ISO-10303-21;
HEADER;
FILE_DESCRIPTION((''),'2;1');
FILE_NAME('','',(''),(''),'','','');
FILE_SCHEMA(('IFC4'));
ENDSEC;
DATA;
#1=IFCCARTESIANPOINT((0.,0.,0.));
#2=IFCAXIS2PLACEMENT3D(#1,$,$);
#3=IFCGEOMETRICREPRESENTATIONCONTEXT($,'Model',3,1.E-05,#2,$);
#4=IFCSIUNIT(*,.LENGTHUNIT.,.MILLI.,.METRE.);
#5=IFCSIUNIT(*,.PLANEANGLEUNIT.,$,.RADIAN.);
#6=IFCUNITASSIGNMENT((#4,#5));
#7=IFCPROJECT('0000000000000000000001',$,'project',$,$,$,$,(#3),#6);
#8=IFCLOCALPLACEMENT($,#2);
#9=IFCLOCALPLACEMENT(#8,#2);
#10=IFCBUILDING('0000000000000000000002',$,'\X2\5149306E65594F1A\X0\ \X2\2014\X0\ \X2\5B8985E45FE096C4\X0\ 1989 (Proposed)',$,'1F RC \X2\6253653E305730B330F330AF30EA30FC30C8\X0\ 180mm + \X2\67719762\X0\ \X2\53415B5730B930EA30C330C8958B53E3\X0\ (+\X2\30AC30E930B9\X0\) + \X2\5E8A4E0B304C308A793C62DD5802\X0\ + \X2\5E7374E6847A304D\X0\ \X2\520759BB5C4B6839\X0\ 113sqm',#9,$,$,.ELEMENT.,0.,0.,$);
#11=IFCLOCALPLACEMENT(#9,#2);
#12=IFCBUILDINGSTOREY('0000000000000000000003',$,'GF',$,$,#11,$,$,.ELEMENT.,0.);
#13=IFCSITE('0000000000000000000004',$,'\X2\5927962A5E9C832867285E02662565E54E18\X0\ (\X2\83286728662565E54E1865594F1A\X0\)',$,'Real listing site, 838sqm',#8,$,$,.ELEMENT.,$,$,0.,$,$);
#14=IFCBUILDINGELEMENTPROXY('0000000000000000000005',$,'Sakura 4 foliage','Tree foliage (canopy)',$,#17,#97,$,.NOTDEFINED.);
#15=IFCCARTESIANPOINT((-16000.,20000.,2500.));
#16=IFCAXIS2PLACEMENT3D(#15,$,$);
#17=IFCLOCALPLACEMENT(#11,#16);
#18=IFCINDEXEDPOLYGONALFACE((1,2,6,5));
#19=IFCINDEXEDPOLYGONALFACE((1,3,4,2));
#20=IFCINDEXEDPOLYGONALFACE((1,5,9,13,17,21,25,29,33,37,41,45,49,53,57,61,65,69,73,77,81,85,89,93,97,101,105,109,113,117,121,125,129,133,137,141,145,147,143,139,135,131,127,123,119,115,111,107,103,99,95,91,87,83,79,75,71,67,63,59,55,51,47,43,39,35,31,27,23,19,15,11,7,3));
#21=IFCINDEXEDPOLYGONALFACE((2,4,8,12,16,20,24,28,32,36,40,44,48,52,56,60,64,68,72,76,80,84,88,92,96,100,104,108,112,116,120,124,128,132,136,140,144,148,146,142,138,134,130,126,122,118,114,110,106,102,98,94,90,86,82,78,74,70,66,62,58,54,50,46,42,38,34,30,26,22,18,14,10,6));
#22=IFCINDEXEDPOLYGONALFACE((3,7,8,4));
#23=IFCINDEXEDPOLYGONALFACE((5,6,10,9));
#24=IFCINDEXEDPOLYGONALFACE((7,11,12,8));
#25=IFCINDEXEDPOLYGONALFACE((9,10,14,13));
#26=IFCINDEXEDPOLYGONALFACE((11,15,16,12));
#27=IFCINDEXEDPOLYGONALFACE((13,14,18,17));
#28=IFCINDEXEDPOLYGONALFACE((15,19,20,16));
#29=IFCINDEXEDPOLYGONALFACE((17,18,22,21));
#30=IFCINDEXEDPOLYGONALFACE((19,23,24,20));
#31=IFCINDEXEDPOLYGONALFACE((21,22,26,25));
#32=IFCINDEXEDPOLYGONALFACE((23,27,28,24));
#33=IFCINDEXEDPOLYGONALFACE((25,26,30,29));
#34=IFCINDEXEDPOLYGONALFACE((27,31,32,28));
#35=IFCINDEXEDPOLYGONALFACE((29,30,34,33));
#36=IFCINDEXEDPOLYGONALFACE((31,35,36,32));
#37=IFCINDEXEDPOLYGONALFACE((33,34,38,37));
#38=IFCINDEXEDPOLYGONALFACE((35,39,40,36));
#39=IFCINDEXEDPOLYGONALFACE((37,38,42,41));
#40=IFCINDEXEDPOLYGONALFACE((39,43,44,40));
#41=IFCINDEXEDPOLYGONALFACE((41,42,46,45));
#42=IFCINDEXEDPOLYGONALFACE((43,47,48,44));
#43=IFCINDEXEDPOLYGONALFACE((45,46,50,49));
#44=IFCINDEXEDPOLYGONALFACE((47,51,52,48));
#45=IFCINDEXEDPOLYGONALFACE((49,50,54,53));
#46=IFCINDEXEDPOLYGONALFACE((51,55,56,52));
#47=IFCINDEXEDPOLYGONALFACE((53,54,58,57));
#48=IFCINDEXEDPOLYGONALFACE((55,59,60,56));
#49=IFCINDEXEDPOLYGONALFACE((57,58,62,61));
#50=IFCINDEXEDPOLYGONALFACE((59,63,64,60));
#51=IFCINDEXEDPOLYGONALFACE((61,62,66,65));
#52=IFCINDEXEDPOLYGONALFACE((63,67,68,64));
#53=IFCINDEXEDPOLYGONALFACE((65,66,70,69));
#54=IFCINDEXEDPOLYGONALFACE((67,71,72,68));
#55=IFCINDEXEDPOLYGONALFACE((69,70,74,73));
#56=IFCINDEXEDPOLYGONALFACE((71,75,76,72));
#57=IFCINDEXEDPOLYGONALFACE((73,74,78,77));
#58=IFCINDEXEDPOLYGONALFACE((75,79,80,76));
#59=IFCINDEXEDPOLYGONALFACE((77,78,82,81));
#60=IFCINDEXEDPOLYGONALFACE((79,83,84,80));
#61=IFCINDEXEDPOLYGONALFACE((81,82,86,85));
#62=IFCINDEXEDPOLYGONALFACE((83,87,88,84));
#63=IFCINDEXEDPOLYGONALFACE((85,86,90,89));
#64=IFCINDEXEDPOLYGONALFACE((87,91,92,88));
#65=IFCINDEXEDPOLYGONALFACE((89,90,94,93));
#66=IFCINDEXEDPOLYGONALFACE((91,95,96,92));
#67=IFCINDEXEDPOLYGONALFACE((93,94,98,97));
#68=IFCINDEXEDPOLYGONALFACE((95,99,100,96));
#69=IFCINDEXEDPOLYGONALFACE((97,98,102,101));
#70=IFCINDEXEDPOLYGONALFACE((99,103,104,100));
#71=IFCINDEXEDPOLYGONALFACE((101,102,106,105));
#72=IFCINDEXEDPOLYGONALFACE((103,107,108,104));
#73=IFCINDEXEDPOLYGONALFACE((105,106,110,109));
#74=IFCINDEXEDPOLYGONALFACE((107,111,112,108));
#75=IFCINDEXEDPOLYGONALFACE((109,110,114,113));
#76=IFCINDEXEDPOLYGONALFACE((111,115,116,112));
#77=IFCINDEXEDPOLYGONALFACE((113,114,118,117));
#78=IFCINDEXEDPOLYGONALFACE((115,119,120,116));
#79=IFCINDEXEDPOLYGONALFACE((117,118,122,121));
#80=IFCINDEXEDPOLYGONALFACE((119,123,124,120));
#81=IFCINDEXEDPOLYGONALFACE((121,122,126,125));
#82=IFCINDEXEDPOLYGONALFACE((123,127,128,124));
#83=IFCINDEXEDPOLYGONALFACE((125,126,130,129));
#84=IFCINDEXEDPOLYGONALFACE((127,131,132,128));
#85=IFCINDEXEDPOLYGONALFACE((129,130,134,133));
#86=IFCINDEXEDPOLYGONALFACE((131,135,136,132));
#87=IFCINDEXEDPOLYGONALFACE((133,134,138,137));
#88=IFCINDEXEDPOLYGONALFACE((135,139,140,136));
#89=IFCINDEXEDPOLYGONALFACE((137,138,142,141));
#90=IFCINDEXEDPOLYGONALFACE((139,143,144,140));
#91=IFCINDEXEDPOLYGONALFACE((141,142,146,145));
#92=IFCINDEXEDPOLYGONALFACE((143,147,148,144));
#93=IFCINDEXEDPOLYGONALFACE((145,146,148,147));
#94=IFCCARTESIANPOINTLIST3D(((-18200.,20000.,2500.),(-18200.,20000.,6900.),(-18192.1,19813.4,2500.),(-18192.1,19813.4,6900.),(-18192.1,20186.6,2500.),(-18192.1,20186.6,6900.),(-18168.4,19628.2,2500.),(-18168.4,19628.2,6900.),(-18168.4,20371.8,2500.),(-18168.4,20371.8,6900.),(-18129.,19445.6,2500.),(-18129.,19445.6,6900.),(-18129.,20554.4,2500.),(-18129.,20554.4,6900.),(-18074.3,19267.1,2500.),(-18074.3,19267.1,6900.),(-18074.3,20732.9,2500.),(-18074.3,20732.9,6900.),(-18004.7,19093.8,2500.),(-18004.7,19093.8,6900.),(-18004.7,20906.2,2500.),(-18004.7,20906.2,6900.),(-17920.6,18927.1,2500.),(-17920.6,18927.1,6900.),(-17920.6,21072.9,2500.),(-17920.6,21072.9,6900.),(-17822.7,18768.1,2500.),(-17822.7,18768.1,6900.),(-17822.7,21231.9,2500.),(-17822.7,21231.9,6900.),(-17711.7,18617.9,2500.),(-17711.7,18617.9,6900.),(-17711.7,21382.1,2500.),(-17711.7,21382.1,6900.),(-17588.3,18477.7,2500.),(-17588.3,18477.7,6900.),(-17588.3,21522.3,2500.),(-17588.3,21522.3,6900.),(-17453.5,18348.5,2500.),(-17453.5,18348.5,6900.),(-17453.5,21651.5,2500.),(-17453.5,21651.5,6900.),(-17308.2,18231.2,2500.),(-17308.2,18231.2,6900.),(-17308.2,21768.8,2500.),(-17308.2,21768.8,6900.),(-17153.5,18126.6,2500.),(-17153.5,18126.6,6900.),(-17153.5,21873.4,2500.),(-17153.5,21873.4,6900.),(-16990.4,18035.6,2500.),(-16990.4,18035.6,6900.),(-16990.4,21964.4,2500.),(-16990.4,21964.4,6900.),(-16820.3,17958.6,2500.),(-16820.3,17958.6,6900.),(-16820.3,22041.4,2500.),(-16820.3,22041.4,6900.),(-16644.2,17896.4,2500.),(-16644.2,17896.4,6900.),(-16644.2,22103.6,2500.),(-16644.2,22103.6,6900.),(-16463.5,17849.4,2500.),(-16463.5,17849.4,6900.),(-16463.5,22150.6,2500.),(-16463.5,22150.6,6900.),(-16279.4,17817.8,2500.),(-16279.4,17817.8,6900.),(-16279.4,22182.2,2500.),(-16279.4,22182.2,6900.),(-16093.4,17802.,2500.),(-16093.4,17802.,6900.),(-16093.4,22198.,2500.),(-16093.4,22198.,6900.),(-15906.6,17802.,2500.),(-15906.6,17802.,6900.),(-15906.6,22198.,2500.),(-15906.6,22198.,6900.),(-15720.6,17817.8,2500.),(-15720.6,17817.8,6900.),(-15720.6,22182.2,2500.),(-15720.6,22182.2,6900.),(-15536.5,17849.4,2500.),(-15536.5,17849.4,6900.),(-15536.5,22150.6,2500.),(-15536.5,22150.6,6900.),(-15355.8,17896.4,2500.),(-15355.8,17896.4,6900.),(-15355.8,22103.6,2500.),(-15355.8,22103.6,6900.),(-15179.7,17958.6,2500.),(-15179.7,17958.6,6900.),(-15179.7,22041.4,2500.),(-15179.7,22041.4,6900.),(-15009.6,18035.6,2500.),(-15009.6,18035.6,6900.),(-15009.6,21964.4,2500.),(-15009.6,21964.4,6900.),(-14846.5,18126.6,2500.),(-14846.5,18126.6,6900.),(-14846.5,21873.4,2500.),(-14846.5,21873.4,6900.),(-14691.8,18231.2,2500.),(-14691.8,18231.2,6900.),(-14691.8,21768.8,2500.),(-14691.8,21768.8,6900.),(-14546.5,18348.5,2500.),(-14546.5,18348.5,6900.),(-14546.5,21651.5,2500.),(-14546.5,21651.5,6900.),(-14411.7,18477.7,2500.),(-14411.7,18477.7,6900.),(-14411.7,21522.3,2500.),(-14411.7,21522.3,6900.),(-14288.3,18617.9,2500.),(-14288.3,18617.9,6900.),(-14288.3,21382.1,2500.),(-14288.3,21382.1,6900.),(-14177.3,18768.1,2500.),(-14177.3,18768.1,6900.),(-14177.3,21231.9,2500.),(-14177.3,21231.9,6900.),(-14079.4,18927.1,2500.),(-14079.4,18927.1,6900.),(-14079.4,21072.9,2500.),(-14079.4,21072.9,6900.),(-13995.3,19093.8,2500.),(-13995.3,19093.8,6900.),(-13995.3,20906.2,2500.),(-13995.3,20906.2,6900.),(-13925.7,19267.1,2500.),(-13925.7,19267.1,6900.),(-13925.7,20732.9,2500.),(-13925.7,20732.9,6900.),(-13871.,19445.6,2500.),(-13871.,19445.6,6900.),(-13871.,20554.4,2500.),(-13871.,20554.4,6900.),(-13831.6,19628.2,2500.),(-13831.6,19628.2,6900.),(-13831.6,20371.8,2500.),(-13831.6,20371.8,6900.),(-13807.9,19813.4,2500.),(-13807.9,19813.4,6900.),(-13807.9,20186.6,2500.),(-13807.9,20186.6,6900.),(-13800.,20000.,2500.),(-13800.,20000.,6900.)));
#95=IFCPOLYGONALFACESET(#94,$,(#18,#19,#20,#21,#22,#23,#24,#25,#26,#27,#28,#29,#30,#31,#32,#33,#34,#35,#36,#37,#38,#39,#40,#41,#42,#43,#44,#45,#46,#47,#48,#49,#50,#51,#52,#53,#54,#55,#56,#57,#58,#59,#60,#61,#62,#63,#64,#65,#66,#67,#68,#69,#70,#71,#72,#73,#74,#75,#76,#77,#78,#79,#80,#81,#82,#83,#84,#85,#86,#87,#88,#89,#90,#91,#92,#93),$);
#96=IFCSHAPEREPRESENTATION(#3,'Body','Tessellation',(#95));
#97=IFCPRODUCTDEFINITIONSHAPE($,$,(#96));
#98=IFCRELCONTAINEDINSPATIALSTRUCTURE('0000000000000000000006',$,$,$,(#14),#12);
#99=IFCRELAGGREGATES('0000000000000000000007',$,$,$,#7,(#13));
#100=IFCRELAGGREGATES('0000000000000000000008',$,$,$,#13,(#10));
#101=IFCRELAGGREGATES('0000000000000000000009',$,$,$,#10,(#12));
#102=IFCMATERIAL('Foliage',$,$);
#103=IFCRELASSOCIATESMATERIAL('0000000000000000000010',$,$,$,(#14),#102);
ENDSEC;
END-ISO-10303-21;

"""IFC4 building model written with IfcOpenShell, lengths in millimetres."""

from ifc_helpers import new_model, si_unit, frame, origin, origin_2d, place, context, project, spatial, circle, extrude, material, element, save


model = new_model("IFC4")

# Units and contexts
model_context = context("Model", 3, precision=1e-05, world=origin())
ifc_project = project(units=[si_unit("LENGTHUNIT", "METRE", prefix="MILLI"), si_unit("PLANEANGLEUNIT", "RADIAN")], contexts=[model_context])

# Site, building, storey
site_placement = place(None, origin())
site = spatial("IfcSite", under=ifc_project, at=site_placement, Name="大阪府茨木市春日丘 (茨木春日丘教会)", ObjectType="Real listing site, 838sqm", CompositionType="ELEMENT", RefElevation=0.0)
building_placement = place(site_placement, origin())
building = spatial("IfcBuilding", under=site, at=building_placement, Name="光の教会 — 安藤忠雄 1989 (Proposed)", ObjectType="1F RC 打放しコンクリート 180mm + 東面 十字スリット開口 (+ガラス) + 床下がり礼拝堂 + 平瓦葺き 切妻屋根 113sqm", CompositionType="ELEMENT", ElevationOfRefHeight=0.0, ElevationOfTerrain=0.0)
storey_placement = place(building_placement, origin())
storey = spatial("IfcBuildingStorey", under=building, at=storey_placement, Name="GF", CompositionType="ELEMENT", Elevation=0.0)

# Building element proxy
ifc_material_1 = material(Name="Foliage")
proxy_1_placement = place(storey_placement, frame((-16000.0, 20000.0, 2500.0)))
element("IfcBuildingElementProxy", 1, at=proxy_1_placement, inside=storey, material=ifc_material_1, Name="Sakura 4 foliage", Description="Tree foliage (canopy)", PredefinedType="NOTDEFINED", context=model_context, shape_type="SweptSolid", body=[
    extrude(circle(Radius=2200.0, at=origin_2d()), frame((-16000.0, 20000.0, 2500.0)), (0.0, 0.0, 1.0), 4400.0),
])

save(model, "model.ifc")
